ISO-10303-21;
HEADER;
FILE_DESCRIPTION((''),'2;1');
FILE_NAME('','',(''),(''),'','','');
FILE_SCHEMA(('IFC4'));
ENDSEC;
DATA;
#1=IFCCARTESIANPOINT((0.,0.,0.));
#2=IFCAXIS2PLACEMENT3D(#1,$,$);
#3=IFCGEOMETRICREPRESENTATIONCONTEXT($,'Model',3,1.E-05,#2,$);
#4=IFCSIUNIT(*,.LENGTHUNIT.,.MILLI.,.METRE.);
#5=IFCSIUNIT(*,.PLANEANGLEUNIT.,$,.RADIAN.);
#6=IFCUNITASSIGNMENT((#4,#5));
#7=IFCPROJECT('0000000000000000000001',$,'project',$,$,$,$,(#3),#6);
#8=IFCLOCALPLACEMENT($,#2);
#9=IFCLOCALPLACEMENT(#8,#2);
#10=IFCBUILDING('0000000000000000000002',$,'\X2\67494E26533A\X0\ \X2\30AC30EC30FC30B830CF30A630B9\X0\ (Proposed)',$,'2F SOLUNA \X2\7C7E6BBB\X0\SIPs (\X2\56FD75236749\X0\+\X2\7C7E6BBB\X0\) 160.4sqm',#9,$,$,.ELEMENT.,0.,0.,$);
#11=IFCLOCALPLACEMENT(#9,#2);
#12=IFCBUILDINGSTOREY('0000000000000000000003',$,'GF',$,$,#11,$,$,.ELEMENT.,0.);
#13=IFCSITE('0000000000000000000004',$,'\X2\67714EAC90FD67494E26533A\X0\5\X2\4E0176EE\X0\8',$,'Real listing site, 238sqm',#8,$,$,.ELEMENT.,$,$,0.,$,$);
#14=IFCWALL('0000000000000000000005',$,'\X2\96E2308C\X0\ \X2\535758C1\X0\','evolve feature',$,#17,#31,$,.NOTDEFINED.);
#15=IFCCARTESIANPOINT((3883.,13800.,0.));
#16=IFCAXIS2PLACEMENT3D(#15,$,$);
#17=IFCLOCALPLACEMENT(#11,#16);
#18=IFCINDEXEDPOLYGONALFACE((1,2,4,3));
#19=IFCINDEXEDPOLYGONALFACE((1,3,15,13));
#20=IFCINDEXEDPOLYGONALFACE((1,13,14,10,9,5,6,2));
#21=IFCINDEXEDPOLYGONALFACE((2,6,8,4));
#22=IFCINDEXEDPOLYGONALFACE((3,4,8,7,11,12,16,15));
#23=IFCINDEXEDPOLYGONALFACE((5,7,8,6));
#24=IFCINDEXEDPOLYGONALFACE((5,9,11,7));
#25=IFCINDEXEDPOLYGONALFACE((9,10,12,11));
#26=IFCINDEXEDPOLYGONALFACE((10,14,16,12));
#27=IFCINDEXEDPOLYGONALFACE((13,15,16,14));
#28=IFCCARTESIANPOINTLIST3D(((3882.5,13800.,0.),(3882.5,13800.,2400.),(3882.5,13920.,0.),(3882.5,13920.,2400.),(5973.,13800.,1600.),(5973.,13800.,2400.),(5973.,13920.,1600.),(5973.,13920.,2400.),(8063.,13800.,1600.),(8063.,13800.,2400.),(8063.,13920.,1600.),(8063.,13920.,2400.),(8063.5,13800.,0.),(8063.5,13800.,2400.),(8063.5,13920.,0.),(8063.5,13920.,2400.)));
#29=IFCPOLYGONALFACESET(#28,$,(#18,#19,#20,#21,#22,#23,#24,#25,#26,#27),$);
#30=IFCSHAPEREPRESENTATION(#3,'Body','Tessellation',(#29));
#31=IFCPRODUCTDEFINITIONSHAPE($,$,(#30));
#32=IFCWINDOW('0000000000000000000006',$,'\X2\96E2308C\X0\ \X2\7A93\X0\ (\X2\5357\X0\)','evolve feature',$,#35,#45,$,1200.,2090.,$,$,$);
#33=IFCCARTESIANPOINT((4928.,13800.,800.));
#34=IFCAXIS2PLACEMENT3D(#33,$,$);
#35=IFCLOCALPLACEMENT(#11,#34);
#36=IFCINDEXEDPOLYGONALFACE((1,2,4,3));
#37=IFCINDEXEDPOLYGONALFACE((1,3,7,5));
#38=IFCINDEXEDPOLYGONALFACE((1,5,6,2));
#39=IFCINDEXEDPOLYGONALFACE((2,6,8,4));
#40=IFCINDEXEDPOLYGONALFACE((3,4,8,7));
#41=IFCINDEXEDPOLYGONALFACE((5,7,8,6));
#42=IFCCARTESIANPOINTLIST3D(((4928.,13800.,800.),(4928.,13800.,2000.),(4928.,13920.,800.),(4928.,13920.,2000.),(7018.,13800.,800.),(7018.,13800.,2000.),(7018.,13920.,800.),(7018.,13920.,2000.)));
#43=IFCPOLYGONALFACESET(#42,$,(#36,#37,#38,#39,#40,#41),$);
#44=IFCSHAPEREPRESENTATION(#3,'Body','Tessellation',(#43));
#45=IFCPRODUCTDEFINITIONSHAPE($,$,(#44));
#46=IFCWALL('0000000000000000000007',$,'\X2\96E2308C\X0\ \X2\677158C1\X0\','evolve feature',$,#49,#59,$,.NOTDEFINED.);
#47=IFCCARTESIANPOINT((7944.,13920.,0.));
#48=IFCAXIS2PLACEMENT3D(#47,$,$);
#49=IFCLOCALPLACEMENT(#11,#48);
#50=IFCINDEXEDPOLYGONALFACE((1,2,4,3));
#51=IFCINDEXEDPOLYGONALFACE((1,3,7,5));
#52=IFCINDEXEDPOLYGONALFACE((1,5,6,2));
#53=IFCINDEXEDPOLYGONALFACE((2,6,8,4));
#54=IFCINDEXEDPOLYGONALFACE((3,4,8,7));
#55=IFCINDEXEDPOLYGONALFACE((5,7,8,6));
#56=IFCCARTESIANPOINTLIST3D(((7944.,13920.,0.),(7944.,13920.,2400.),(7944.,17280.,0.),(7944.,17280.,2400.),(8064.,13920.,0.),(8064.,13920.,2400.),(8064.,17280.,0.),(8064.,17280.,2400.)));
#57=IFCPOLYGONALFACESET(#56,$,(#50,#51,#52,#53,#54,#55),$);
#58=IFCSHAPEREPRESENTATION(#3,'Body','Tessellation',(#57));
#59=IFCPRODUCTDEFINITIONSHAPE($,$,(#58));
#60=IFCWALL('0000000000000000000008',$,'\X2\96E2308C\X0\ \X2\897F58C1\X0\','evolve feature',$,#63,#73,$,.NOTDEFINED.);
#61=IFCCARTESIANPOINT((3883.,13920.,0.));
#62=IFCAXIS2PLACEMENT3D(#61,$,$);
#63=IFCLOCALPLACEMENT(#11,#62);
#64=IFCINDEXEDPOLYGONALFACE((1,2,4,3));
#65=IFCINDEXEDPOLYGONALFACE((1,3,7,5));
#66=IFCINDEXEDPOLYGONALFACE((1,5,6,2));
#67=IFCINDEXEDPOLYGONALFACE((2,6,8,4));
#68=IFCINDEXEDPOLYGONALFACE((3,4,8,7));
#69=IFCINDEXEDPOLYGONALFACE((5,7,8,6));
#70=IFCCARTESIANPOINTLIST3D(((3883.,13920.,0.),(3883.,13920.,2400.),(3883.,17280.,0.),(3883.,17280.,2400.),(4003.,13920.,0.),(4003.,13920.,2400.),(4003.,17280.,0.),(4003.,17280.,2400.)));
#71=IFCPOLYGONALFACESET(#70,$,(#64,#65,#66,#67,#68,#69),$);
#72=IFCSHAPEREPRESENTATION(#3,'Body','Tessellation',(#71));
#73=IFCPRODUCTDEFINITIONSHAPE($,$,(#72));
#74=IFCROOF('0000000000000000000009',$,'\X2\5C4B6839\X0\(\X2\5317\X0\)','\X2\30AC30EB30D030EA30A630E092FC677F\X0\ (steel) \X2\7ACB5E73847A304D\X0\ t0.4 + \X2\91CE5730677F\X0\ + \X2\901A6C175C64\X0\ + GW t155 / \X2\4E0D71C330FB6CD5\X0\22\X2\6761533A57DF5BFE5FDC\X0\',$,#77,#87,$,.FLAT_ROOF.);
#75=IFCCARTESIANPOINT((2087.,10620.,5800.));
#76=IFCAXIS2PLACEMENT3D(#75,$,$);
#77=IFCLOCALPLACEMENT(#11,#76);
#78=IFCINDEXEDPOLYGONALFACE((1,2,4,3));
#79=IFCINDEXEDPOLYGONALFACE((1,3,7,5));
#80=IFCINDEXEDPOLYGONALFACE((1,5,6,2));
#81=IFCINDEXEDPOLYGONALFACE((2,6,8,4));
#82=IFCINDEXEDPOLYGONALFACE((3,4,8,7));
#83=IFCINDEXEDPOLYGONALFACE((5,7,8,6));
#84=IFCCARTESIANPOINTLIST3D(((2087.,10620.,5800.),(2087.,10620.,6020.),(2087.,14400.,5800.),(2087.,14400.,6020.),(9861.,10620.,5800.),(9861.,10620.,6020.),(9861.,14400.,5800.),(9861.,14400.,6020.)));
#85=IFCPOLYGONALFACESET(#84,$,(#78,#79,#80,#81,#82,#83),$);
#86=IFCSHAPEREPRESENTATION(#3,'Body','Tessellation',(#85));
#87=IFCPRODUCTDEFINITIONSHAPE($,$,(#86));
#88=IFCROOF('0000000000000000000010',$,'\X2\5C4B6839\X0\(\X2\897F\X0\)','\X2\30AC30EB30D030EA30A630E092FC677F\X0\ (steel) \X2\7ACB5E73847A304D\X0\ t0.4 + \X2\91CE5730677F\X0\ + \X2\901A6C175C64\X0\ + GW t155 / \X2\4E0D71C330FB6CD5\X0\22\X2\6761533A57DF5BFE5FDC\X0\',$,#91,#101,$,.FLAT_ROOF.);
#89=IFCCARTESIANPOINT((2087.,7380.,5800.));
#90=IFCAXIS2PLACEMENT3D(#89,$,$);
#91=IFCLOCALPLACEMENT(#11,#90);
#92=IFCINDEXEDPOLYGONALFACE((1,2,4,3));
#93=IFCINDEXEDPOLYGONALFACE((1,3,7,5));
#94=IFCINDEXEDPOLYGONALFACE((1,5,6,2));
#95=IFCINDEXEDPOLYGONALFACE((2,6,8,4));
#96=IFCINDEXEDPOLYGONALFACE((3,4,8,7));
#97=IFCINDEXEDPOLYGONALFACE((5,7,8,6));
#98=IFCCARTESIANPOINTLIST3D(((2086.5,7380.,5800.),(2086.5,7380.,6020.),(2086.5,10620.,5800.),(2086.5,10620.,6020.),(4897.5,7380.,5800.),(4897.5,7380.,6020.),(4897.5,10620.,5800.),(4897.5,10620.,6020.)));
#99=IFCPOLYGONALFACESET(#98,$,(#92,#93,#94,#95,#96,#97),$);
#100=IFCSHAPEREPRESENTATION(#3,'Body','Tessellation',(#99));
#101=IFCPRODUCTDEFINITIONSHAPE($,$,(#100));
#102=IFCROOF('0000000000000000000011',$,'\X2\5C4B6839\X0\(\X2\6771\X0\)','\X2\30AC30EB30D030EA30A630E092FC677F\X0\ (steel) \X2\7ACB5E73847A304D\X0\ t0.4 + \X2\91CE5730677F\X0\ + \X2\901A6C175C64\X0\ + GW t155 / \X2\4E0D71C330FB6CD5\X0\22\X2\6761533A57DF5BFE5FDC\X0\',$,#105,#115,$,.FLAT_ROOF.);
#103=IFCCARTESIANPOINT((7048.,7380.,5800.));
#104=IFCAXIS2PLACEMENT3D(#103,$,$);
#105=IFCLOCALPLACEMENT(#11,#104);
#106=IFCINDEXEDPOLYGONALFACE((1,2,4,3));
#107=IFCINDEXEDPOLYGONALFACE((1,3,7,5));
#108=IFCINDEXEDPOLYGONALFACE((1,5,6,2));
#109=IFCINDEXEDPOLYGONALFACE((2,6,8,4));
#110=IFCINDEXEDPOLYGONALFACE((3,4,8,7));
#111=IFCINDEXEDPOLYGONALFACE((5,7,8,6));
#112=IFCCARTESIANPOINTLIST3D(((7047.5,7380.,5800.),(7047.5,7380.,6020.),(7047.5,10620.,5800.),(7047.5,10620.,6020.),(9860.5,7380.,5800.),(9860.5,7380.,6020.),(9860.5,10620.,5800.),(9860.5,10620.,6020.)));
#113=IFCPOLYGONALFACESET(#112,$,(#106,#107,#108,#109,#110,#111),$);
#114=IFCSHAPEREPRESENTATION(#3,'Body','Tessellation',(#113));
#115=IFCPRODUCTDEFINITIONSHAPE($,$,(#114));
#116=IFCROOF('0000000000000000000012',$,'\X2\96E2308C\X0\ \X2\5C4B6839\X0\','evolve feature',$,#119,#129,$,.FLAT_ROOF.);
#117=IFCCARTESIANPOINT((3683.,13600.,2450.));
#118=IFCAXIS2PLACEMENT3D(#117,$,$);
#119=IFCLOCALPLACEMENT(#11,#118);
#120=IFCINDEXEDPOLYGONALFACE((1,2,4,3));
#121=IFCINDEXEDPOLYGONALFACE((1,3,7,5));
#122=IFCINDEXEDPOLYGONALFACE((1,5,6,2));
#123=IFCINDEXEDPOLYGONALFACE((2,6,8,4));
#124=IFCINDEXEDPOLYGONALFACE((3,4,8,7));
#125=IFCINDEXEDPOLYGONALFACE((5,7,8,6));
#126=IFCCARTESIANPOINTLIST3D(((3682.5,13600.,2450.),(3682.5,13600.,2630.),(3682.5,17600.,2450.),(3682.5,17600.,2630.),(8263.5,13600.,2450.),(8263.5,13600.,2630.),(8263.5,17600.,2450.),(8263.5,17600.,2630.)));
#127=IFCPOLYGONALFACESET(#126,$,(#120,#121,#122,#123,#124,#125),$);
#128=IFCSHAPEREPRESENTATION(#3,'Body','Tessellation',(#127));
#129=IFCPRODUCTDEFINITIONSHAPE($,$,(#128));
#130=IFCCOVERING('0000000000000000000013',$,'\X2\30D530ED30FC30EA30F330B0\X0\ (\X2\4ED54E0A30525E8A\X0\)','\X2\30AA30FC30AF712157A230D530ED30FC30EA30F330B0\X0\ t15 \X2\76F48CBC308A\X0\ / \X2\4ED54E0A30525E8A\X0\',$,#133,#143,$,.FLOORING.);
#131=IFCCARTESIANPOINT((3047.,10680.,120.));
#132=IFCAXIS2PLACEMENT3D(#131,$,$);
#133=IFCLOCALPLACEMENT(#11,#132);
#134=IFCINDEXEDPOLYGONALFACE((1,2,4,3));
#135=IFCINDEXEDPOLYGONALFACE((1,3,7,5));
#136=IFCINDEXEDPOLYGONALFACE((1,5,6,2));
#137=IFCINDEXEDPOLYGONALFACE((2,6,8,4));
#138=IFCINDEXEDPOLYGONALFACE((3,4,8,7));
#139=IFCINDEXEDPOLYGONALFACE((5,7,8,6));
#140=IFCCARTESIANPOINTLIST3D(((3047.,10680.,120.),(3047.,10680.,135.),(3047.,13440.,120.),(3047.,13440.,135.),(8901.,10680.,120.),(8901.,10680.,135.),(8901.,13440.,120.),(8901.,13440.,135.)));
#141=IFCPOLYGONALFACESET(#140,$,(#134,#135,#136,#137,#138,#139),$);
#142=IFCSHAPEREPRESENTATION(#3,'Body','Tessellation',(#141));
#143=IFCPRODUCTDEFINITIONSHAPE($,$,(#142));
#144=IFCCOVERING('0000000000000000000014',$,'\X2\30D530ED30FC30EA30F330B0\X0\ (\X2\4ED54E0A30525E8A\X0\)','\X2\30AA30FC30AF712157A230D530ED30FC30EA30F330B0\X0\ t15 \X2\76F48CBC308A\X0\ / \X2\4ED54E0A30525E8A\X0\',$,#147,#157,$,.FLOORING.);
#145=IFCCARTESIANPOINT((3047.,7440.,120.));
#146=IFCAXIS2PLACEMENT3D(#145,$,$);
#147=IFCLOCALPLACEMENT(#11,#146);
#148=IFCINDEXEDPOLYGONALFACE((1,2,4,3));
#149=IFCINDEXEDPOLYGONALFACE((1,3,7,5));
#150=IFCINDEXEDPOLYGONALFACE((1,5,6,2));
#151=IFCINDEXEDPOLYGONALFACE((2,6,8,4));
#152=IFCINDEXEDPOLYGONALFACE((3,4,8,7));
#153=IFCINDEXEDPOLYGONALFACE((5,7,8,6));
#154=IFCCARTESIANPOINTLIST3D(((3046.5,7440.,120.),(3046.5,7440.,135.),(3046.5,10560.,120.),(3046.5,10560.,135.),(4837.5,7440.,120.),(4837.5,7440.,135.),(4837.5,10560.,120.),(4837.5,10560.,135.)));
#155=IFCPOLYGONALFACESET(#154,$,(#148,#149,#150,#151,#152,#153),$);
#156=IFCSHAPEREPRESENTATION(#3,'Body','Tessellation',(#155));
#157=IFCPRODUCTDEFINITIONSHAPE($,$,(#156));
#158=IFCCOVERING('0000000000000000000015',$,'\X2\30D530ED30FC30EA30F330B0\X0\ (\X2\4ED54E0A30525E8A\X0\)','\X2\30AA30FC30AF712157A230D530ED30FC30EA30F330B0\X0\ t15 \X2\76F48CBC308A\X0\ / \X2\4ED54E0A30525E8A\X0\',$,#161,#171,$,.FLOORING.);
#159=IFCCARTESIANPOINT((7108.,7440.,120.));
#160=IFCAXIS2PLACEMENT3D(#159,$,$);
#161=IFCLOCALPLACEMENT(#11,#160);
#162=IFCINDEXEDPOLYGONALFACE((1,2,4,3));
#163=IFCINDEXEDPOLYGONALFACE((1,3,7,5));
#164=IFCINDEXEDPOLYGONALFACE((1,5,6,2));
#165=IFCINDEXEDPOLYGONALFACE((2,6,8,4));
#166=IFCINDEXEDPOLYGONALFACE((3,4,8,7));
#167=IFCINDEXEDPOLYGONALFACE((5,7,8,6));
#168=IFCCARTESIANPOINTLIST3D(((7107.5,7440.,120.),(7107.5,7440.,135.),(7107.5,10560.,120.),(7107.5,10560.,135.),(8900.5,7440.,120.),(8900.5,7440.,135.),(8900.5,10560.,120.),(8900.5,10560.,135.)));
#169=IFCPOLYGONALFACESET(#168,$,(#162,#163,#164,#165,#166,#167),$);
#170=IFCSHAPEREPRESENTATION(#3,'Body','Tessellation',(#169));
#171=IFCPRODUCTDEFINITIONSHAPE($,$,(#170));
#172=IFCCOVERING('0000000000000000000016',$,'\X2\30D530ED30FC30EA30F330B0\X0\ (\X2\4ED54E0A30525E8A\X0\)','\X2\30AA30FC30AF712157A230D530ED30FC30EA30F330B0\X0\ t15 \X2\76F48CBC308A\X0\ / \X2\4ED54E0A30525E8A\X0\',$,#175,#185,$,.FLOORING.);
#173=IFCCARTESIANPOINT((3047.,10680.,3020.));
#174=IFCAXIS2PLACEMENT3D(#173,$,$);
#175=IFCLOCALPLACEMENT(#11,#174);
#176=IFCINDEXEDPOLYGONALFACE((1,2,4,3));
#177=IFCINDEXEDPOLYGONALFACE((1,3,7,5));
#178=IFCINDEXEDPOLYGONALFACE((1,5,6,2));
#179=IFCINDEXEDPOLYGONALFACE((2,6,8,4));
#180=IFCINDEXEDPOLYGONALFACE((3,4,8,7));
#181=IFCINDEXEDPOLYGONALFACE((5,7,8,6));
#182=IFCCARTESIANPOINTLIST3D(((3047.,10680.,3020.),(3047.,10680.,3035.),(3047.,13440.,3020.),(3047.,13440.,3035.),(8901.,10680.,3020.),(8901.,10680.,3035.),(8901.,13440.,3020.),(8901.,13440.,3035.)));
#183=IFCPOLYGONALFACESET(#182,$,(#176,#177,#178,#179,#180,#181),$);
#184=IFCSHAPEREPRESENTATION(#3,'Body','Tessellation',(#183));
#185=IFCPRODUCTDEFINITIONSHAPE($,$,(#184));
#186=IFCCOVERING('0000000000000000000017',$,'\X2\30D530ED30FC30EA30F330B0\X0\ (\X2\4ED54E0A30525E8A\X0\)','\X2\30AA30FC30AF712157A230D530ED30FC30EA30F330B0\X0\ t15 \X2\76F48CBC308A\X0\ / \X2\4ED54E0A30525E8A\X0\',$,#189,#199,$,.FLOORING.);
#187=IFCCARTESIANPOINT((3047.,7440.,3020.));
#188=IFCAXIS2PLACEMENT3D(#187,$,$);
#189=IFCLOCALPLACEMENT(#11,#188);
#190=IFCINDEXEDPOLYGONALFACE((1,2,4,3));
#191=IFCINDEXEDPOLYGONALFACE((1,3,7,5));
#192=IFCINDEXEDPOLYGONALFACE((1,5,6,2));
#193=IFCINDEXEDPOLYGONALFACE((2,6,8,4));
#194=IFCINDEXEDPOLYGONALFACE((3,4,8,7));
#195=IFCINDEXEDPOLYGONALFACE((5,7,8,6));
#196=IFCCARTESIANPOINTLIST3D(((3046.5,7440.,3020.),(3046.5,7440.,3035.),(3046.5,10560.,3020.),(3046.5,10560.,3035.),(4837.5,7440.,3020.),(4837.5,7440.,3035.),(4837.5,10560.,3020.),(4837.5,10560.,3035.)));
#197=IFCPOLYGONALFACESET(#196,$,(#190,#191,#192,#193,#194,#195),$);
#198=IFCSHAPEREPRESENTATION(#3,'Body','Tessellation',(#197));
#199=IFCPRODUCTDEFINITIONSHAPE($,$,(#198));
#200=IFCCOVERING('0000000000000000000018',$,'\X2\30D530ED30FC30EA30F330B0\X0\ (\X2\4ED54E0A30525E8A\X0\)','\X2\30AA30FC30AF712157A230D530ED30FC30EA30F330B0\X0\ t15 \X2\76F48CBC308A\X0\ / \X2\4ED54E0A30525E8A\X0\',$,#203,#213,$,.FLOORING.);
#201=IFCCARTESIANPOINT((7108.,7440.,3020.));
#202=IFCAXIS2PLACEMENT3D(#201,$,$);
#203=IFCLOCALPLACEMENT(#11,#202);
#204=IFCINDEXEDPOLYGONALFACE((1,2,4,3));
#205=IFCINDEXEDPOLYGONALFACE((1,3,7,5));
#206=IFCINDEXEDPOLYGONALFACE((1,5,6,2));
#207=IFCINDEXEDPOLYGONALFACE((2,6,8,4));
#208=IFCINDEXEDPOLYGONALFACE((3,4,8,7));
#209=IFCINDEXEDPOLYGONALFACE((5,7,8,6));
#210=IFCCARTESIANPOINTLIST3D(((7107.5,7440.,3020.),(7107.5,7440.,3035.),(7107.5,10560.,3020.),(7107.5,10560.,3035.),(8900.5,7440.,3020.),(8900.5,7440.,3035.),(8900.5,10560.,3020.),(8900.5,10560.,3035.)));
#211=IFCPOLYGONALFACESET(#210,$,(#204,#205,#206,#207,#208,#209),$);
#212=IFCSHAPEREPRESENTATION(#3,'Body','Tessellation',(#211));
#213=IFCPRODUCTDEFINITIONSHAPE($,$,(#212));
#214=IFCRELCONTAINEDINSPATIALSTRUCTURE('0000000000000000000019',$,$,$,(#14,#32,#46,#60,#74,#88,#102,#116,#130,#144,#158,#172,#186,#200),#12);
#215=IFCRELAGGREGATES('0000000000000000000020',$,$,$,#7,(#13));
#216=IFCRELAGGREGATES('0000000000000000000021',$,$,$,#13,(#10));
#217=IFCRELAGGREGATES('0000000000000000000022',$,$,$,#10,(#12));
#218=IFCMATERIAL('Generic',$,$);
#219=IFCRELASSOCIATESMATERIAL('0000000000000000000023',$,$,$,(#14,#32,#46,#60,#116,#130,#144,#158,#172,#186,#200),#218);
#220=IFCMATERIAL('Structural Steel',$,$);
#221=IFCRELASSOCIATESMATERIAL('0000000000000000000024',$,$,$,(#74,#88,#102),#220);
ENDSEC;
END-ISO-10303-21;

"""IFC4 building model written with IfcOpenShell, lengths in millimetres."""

from ifc_helpers import new_model, si_unit, frame, frame_2d, origin, place, context, project, spatial, rectangle, extrude, material, element, fill, save


model = new_model("IFC4")

# Units and contexts
model_context = context("Model", 3, precision=1e-05, world=origin())
ifc_project = project(units=[si_unit("LENGTHUNIT", "METRE", prefix="MILLI"), si_unit("PLANEANGLEUNIT", "RADIAN")], contexts=[model_context])

# Site, building, storey
site_placement = place(None, origin())
site = spatial("IfcSite", under=ifc_project, at=site_placement, Name="東京都杉並区5丁目8", ObjectType="Real listing site, 238sqm", CompositionType="ELEMENT", RefElevation=0.0)
building_placement = place(site_placement, origin())
building = spatial("IfcBuilding", under=site, at=building_placement, Name="杉並区 ガレージハウス (Proposed)", ObjectType="2F SOLUNA 籾殻SIPs (国産杉+籾殻) 160.4sqm", CompositionType="ELEMENT", ElevationOfRefHeight=0.0, ElevationOfTerrain=0.0)
storey_placement = place(building_placement, origin())
storey = spatial("IfcBuildingStorey", under=building, at=storey_placement, Name="GF", CompositionType="ELEMENT", Elevation=0.0)

# Shared definitions
ifc_material_1 = material(Name="Generic")

# Wall, opening, window
wall_1_placement = place(storey_placement, frame((3883.0, 13800.0, 0.0)))
wall_1 = element("IfcWall", 1, at=wall_1_placement, inside=storey, material=ifc_material_1, Name="離れ 南壁", Description="evolve feature", PredefinedType="NOTDEFINED", context=model_context, shape_type="SweptSolid", body=[
    extrude(rectangle(XDim=4181.0, YDim=120.0, at=frame_2d((2090.0, 60.0))), frame((3883.0, 13800.0, 0.0)), (0.0, 0.0, 1.0), 2400.0),
])
opening_1_placement = place(storey_placement, frame((4928.0, 13800.0, 800.0)))
opening_1 = element("IfcOpeningElement", 2, at=opening_1_placement, cuts=wall_1, PredefinedType="NOTDEFINED", context=model_context, shape_type="SweptSolid", body=[
    extrude(rectangle(XDim=2090.0, YDim=120.0, at=frame_2d((1045.0, 60.0))), frame((4928.0, 13800.0, 800.0)), (0.0, 0.0, 1.0), 1200.0),
])
window_1_placement = place(storey_placement, frame((4928.0, 13800.0, 800.0)))
window_1 = element("IfcWindow", 3, at=window_1_placement, inside=storey, material=ifc_material_1, Name="離れ 窓 (南)", Description="evolve feature", OverallHeight=1200.0, OverallWidth=2090.0, context=model_context, shape_type="SweptSolid", body=[
    extrude(rectangle(XDim=2090.0, YDim=120.0, at=frame_2d((1045.0, 60.0))), frame((4928.0, 13800.0, 800.0)), (0.0, 0.0, 1.0), 1200.0),
])
fill(opening_1, window_1)

# Walls
wall_2_placement = place(storey_placement, frame((7944.0, 13920.0, 0.0)))
element("IfcWall", 4, at=wall_2_placement, inside=storey, material=ifc_material_1, Name="離れ 東壁", Description="evolve feature", PredefinedType="NOTDEFINED", context=model_context, shape_type="SweptSolid", body=[
    extrude(rectangle(XDim=120.0, YDim=3360.0, at=frame_2d((60.0, 1680.0))), frame((7944.0, 13920.0, 0.0)), (0.0, 0.0, 1.0), 2400.0),
])
wall_3_placement = place(storey_placement, frame((3883.0, 13920.0, 0.0)))
element("IfcWall", 5, at=wall_3_placement, inside=storey, material=ifc_material_1, Name="離れ 西壁", Description="evolve feature", PredefinedType="NOTDEFINED", context=model_context, shape_type="SweptSolid", body=[
    extrude(rectangle(XDim=120.0, YDim=3360.0, at=frame_2d((60.0, 1680.0))), frame((3883.0, 13920.0, 0.0)), (0.0, 0.0, 1.0), 2400.0),
])

# Roofs
ifc_material_2 = material(Name="Structural Steel")
for number, where, name in (
    (6, (2087.0, 10620.0, 5800.0), "屋根(北)"),
):
    element("IfcRoof", number, at=place(storey_placement, frame(where)), inside=storey, material=ifc_material_2, Name=name, Description="ガルバリウム鋼板 (steel) 立平葺き t0.4 + 野地板 + 通気層 + GW t155 / 不燃・法22条区域対応", PredefinedType="FLAT_ROOF", context=model_context, shape_type="SweptSolid", body=[
        extrude(rectangle(XDim=7774.0, YDim=3780.0, at=frame_2d((3887.0, 1890.0))), frame((2087.0, 10620.0, 5800.0)), (0.0, 0.0, 1.0), 220.0),
    ])
roof_1_placement = place(storey_placement, frame((2087.0, 7380.0, 5800.0)))
element("IfcRoof", 7, at=roof_1_placement, inside=storey, material=ifc_material_2, Name="屋根(西)", Description="ガルバリウム鋼板 (steel) 立平葺き t0.4 + 野地板 + 通気層 + GW t155 / 不燃・法22条区域対応", PredefinedType="FLAT_ROOF", context=model_context, shape_type="SweptSolid", body=[
    extrude(rectangle(XDim=2811.0, YDim=3240.0, at=frame_2d((1405.0, 1620.0))), frame((2087.0, 7380.0, 5800.0)), (0.0, 0.0, 1.0), 220.0),
])
roof_2_placement = place(storey_placement, frame((7048.0, 7380.0, 5800.0)))
element("IfcRoof", 8, at=roof_2_placement, inside=storey, material=ifc_material_2, Name="屋根(東)", Description="ガルバリウム鋼板 (steel) 立平葺き t0.4 + 野地板 + 通気層 + GW t155 / 不燃・法22条区域対応", PredefinedType="FLAT_ROOF", context=model_context, shape_type="SweptSolid", body=[
    extrude(rectangle(XDim=2813.0, YDim=3240.0, at=frame_2d((1406.0, 1620.0))), frame((7048.0, 7380.0, 5800.0)), (0.0, 0.0, 1.0), 220.0),
])
roof_3_placement = place(storey_placement, frame((3683.0, 13600.0, 2450.0)))
element("IfcRoof", 9, at=roof_3_placement, inside=storey, material=ifc_material_1, Name="離れ 屋根", Description="evolve feature", PredefinedType="FLAT_ROOF", context=model_context, shape_type="SweptSolid", body=[
    extrude(rectangle(XDim=4581.0, YDim=4000.0, at=frame_2d((2290.0, 2000.0))), frame((3683.0, 13600.0, 2450.0)), (0.0, 0.0, 1.0), 180.0),
])

# Coverings
covering_1_placement = place(storey_placement, frame((3047.0, 10680.0, 120.0)))
element("IfcCovering", 10, at=covering_1_placement, inside=storey, material=ifc_material_1, Name="フローリング (仕上げ床)", Description="オーク無垢フローリング t15 直貼り / 仕上げ床", PredefinedType="FLOORING", context=model_context, shape_type="SweptSolid", body=[
    extrude(rectangle(XDim=5854.0, YDim=2760.0, at=frame_2d((2927.0, 1380.0))), frame((3047.0, 10680.0, 120.0)), (0.0, 0.0, 1.0), 15.0),
])
covering_2_placement = place(storey_placement, frame((3047.0, 7440.0, 120.0)))
element("IfcCovering", 11, at=covering_2_placement, inside=storey, material=ifc_material_1, Name="フローリング (仕上げ床)", Description="オーク無垢フローリング t15 直貼り / 仕上げ床", PredefinedType="FLOORING", context=model_context, shape_type="SweptSolid", body=[
    extrude(rectangle(XDim=1791.0, YDim=3120.0, at=frame_2d((895.0, 1560.0))), frame((3047.0, 7440.0, 120.0)), (0.0, 0.0, 1.0), 15.0),
])
covering_3_placement = place(storey_placement, frame((7108.0, 7440.0, 120.0)))
element("IfcCovering", 12, at=covering_3_placement, inside=storey, material=ifc_material_1, Name="フローリング (仕上げ床)", Description="オーク無垢フローリング t15 直貼り / 仕上げ床", PredefinedType="FLOORING", context=model_context, shape_type="SweptSolid", body=[
    extrude(rectangle(XDim=1793.0, YDim=3120.0, at=frame_2d((896.0, 1560.0))), frame((7108.0, 7440.0, 120.0)), (0.0, 0.0, 1.0), 15.0),
])
covering_4_placement = place(storey_placement, frame((3047.0, 10680.0, 3020.0)))
element("IfcCovering", 13, at=covering_4_placement, inside=storey, material=ifc_material_1, Name="フローリング (仕上げ床)", Description="オーク無垢フローリング t15 直貼り / 仕上げ床", PredefinedType="FLOORING", context=model_context, shape_type="SweptSolid", body=[
    extrude(rectangle(XDim=5854.0, YDim=2760.0, at=frame_2d((2927.0, 1380.0))), frame((3047.0, 10680.0, 3020.0)), (0.0, 0.0, 1.0), 15.0),
])
covering_5_placement = place(storey_placement, frame((3047.0, 7440.0, 3020.0)))
element("IfcCovering", 14, at=covering_5_placement, inside=storey, material=ifc_material_1, Name="フローリング (仕上げ床)", Description="オーク無垢フローリング t15 直貼り / 仕上げ床", PredefinedType="FLOORING", context=model_context, shape_type="SweptSolid", body=[
    extrude(rectangle(XDim=1791.0, YDim=3120.0, at=frame_2d((895.0, 1560.0))), frame((3047.0, 7440.0, 3020.0)), (0.0, 0.0, 1.0), 15.0),
])
covering_6_placement = place(storey_placement, frame((7108.0, 7440.0, 3020.0)))
element("IfcCovering", 15, at=covering_6_placement, inside=storey, material=ifc_material_1, Name="フローリング (仕上げ床)", Description="オーク無垢フローリング t15 直貼り / 仕上げ床", PredefinedType="FLOORING", context=model_context, shape_type="SweptSolid", body=[
    extrude(rectangle(XDim=1793.0, YDim=3120.0, at=frame_2d((896.0, 1560.0))), frame((7108.0, 7440.0, 3020.0)), (0.0, 0.0, 1.0), 15.0),
])

save(model, "model.ifc")
